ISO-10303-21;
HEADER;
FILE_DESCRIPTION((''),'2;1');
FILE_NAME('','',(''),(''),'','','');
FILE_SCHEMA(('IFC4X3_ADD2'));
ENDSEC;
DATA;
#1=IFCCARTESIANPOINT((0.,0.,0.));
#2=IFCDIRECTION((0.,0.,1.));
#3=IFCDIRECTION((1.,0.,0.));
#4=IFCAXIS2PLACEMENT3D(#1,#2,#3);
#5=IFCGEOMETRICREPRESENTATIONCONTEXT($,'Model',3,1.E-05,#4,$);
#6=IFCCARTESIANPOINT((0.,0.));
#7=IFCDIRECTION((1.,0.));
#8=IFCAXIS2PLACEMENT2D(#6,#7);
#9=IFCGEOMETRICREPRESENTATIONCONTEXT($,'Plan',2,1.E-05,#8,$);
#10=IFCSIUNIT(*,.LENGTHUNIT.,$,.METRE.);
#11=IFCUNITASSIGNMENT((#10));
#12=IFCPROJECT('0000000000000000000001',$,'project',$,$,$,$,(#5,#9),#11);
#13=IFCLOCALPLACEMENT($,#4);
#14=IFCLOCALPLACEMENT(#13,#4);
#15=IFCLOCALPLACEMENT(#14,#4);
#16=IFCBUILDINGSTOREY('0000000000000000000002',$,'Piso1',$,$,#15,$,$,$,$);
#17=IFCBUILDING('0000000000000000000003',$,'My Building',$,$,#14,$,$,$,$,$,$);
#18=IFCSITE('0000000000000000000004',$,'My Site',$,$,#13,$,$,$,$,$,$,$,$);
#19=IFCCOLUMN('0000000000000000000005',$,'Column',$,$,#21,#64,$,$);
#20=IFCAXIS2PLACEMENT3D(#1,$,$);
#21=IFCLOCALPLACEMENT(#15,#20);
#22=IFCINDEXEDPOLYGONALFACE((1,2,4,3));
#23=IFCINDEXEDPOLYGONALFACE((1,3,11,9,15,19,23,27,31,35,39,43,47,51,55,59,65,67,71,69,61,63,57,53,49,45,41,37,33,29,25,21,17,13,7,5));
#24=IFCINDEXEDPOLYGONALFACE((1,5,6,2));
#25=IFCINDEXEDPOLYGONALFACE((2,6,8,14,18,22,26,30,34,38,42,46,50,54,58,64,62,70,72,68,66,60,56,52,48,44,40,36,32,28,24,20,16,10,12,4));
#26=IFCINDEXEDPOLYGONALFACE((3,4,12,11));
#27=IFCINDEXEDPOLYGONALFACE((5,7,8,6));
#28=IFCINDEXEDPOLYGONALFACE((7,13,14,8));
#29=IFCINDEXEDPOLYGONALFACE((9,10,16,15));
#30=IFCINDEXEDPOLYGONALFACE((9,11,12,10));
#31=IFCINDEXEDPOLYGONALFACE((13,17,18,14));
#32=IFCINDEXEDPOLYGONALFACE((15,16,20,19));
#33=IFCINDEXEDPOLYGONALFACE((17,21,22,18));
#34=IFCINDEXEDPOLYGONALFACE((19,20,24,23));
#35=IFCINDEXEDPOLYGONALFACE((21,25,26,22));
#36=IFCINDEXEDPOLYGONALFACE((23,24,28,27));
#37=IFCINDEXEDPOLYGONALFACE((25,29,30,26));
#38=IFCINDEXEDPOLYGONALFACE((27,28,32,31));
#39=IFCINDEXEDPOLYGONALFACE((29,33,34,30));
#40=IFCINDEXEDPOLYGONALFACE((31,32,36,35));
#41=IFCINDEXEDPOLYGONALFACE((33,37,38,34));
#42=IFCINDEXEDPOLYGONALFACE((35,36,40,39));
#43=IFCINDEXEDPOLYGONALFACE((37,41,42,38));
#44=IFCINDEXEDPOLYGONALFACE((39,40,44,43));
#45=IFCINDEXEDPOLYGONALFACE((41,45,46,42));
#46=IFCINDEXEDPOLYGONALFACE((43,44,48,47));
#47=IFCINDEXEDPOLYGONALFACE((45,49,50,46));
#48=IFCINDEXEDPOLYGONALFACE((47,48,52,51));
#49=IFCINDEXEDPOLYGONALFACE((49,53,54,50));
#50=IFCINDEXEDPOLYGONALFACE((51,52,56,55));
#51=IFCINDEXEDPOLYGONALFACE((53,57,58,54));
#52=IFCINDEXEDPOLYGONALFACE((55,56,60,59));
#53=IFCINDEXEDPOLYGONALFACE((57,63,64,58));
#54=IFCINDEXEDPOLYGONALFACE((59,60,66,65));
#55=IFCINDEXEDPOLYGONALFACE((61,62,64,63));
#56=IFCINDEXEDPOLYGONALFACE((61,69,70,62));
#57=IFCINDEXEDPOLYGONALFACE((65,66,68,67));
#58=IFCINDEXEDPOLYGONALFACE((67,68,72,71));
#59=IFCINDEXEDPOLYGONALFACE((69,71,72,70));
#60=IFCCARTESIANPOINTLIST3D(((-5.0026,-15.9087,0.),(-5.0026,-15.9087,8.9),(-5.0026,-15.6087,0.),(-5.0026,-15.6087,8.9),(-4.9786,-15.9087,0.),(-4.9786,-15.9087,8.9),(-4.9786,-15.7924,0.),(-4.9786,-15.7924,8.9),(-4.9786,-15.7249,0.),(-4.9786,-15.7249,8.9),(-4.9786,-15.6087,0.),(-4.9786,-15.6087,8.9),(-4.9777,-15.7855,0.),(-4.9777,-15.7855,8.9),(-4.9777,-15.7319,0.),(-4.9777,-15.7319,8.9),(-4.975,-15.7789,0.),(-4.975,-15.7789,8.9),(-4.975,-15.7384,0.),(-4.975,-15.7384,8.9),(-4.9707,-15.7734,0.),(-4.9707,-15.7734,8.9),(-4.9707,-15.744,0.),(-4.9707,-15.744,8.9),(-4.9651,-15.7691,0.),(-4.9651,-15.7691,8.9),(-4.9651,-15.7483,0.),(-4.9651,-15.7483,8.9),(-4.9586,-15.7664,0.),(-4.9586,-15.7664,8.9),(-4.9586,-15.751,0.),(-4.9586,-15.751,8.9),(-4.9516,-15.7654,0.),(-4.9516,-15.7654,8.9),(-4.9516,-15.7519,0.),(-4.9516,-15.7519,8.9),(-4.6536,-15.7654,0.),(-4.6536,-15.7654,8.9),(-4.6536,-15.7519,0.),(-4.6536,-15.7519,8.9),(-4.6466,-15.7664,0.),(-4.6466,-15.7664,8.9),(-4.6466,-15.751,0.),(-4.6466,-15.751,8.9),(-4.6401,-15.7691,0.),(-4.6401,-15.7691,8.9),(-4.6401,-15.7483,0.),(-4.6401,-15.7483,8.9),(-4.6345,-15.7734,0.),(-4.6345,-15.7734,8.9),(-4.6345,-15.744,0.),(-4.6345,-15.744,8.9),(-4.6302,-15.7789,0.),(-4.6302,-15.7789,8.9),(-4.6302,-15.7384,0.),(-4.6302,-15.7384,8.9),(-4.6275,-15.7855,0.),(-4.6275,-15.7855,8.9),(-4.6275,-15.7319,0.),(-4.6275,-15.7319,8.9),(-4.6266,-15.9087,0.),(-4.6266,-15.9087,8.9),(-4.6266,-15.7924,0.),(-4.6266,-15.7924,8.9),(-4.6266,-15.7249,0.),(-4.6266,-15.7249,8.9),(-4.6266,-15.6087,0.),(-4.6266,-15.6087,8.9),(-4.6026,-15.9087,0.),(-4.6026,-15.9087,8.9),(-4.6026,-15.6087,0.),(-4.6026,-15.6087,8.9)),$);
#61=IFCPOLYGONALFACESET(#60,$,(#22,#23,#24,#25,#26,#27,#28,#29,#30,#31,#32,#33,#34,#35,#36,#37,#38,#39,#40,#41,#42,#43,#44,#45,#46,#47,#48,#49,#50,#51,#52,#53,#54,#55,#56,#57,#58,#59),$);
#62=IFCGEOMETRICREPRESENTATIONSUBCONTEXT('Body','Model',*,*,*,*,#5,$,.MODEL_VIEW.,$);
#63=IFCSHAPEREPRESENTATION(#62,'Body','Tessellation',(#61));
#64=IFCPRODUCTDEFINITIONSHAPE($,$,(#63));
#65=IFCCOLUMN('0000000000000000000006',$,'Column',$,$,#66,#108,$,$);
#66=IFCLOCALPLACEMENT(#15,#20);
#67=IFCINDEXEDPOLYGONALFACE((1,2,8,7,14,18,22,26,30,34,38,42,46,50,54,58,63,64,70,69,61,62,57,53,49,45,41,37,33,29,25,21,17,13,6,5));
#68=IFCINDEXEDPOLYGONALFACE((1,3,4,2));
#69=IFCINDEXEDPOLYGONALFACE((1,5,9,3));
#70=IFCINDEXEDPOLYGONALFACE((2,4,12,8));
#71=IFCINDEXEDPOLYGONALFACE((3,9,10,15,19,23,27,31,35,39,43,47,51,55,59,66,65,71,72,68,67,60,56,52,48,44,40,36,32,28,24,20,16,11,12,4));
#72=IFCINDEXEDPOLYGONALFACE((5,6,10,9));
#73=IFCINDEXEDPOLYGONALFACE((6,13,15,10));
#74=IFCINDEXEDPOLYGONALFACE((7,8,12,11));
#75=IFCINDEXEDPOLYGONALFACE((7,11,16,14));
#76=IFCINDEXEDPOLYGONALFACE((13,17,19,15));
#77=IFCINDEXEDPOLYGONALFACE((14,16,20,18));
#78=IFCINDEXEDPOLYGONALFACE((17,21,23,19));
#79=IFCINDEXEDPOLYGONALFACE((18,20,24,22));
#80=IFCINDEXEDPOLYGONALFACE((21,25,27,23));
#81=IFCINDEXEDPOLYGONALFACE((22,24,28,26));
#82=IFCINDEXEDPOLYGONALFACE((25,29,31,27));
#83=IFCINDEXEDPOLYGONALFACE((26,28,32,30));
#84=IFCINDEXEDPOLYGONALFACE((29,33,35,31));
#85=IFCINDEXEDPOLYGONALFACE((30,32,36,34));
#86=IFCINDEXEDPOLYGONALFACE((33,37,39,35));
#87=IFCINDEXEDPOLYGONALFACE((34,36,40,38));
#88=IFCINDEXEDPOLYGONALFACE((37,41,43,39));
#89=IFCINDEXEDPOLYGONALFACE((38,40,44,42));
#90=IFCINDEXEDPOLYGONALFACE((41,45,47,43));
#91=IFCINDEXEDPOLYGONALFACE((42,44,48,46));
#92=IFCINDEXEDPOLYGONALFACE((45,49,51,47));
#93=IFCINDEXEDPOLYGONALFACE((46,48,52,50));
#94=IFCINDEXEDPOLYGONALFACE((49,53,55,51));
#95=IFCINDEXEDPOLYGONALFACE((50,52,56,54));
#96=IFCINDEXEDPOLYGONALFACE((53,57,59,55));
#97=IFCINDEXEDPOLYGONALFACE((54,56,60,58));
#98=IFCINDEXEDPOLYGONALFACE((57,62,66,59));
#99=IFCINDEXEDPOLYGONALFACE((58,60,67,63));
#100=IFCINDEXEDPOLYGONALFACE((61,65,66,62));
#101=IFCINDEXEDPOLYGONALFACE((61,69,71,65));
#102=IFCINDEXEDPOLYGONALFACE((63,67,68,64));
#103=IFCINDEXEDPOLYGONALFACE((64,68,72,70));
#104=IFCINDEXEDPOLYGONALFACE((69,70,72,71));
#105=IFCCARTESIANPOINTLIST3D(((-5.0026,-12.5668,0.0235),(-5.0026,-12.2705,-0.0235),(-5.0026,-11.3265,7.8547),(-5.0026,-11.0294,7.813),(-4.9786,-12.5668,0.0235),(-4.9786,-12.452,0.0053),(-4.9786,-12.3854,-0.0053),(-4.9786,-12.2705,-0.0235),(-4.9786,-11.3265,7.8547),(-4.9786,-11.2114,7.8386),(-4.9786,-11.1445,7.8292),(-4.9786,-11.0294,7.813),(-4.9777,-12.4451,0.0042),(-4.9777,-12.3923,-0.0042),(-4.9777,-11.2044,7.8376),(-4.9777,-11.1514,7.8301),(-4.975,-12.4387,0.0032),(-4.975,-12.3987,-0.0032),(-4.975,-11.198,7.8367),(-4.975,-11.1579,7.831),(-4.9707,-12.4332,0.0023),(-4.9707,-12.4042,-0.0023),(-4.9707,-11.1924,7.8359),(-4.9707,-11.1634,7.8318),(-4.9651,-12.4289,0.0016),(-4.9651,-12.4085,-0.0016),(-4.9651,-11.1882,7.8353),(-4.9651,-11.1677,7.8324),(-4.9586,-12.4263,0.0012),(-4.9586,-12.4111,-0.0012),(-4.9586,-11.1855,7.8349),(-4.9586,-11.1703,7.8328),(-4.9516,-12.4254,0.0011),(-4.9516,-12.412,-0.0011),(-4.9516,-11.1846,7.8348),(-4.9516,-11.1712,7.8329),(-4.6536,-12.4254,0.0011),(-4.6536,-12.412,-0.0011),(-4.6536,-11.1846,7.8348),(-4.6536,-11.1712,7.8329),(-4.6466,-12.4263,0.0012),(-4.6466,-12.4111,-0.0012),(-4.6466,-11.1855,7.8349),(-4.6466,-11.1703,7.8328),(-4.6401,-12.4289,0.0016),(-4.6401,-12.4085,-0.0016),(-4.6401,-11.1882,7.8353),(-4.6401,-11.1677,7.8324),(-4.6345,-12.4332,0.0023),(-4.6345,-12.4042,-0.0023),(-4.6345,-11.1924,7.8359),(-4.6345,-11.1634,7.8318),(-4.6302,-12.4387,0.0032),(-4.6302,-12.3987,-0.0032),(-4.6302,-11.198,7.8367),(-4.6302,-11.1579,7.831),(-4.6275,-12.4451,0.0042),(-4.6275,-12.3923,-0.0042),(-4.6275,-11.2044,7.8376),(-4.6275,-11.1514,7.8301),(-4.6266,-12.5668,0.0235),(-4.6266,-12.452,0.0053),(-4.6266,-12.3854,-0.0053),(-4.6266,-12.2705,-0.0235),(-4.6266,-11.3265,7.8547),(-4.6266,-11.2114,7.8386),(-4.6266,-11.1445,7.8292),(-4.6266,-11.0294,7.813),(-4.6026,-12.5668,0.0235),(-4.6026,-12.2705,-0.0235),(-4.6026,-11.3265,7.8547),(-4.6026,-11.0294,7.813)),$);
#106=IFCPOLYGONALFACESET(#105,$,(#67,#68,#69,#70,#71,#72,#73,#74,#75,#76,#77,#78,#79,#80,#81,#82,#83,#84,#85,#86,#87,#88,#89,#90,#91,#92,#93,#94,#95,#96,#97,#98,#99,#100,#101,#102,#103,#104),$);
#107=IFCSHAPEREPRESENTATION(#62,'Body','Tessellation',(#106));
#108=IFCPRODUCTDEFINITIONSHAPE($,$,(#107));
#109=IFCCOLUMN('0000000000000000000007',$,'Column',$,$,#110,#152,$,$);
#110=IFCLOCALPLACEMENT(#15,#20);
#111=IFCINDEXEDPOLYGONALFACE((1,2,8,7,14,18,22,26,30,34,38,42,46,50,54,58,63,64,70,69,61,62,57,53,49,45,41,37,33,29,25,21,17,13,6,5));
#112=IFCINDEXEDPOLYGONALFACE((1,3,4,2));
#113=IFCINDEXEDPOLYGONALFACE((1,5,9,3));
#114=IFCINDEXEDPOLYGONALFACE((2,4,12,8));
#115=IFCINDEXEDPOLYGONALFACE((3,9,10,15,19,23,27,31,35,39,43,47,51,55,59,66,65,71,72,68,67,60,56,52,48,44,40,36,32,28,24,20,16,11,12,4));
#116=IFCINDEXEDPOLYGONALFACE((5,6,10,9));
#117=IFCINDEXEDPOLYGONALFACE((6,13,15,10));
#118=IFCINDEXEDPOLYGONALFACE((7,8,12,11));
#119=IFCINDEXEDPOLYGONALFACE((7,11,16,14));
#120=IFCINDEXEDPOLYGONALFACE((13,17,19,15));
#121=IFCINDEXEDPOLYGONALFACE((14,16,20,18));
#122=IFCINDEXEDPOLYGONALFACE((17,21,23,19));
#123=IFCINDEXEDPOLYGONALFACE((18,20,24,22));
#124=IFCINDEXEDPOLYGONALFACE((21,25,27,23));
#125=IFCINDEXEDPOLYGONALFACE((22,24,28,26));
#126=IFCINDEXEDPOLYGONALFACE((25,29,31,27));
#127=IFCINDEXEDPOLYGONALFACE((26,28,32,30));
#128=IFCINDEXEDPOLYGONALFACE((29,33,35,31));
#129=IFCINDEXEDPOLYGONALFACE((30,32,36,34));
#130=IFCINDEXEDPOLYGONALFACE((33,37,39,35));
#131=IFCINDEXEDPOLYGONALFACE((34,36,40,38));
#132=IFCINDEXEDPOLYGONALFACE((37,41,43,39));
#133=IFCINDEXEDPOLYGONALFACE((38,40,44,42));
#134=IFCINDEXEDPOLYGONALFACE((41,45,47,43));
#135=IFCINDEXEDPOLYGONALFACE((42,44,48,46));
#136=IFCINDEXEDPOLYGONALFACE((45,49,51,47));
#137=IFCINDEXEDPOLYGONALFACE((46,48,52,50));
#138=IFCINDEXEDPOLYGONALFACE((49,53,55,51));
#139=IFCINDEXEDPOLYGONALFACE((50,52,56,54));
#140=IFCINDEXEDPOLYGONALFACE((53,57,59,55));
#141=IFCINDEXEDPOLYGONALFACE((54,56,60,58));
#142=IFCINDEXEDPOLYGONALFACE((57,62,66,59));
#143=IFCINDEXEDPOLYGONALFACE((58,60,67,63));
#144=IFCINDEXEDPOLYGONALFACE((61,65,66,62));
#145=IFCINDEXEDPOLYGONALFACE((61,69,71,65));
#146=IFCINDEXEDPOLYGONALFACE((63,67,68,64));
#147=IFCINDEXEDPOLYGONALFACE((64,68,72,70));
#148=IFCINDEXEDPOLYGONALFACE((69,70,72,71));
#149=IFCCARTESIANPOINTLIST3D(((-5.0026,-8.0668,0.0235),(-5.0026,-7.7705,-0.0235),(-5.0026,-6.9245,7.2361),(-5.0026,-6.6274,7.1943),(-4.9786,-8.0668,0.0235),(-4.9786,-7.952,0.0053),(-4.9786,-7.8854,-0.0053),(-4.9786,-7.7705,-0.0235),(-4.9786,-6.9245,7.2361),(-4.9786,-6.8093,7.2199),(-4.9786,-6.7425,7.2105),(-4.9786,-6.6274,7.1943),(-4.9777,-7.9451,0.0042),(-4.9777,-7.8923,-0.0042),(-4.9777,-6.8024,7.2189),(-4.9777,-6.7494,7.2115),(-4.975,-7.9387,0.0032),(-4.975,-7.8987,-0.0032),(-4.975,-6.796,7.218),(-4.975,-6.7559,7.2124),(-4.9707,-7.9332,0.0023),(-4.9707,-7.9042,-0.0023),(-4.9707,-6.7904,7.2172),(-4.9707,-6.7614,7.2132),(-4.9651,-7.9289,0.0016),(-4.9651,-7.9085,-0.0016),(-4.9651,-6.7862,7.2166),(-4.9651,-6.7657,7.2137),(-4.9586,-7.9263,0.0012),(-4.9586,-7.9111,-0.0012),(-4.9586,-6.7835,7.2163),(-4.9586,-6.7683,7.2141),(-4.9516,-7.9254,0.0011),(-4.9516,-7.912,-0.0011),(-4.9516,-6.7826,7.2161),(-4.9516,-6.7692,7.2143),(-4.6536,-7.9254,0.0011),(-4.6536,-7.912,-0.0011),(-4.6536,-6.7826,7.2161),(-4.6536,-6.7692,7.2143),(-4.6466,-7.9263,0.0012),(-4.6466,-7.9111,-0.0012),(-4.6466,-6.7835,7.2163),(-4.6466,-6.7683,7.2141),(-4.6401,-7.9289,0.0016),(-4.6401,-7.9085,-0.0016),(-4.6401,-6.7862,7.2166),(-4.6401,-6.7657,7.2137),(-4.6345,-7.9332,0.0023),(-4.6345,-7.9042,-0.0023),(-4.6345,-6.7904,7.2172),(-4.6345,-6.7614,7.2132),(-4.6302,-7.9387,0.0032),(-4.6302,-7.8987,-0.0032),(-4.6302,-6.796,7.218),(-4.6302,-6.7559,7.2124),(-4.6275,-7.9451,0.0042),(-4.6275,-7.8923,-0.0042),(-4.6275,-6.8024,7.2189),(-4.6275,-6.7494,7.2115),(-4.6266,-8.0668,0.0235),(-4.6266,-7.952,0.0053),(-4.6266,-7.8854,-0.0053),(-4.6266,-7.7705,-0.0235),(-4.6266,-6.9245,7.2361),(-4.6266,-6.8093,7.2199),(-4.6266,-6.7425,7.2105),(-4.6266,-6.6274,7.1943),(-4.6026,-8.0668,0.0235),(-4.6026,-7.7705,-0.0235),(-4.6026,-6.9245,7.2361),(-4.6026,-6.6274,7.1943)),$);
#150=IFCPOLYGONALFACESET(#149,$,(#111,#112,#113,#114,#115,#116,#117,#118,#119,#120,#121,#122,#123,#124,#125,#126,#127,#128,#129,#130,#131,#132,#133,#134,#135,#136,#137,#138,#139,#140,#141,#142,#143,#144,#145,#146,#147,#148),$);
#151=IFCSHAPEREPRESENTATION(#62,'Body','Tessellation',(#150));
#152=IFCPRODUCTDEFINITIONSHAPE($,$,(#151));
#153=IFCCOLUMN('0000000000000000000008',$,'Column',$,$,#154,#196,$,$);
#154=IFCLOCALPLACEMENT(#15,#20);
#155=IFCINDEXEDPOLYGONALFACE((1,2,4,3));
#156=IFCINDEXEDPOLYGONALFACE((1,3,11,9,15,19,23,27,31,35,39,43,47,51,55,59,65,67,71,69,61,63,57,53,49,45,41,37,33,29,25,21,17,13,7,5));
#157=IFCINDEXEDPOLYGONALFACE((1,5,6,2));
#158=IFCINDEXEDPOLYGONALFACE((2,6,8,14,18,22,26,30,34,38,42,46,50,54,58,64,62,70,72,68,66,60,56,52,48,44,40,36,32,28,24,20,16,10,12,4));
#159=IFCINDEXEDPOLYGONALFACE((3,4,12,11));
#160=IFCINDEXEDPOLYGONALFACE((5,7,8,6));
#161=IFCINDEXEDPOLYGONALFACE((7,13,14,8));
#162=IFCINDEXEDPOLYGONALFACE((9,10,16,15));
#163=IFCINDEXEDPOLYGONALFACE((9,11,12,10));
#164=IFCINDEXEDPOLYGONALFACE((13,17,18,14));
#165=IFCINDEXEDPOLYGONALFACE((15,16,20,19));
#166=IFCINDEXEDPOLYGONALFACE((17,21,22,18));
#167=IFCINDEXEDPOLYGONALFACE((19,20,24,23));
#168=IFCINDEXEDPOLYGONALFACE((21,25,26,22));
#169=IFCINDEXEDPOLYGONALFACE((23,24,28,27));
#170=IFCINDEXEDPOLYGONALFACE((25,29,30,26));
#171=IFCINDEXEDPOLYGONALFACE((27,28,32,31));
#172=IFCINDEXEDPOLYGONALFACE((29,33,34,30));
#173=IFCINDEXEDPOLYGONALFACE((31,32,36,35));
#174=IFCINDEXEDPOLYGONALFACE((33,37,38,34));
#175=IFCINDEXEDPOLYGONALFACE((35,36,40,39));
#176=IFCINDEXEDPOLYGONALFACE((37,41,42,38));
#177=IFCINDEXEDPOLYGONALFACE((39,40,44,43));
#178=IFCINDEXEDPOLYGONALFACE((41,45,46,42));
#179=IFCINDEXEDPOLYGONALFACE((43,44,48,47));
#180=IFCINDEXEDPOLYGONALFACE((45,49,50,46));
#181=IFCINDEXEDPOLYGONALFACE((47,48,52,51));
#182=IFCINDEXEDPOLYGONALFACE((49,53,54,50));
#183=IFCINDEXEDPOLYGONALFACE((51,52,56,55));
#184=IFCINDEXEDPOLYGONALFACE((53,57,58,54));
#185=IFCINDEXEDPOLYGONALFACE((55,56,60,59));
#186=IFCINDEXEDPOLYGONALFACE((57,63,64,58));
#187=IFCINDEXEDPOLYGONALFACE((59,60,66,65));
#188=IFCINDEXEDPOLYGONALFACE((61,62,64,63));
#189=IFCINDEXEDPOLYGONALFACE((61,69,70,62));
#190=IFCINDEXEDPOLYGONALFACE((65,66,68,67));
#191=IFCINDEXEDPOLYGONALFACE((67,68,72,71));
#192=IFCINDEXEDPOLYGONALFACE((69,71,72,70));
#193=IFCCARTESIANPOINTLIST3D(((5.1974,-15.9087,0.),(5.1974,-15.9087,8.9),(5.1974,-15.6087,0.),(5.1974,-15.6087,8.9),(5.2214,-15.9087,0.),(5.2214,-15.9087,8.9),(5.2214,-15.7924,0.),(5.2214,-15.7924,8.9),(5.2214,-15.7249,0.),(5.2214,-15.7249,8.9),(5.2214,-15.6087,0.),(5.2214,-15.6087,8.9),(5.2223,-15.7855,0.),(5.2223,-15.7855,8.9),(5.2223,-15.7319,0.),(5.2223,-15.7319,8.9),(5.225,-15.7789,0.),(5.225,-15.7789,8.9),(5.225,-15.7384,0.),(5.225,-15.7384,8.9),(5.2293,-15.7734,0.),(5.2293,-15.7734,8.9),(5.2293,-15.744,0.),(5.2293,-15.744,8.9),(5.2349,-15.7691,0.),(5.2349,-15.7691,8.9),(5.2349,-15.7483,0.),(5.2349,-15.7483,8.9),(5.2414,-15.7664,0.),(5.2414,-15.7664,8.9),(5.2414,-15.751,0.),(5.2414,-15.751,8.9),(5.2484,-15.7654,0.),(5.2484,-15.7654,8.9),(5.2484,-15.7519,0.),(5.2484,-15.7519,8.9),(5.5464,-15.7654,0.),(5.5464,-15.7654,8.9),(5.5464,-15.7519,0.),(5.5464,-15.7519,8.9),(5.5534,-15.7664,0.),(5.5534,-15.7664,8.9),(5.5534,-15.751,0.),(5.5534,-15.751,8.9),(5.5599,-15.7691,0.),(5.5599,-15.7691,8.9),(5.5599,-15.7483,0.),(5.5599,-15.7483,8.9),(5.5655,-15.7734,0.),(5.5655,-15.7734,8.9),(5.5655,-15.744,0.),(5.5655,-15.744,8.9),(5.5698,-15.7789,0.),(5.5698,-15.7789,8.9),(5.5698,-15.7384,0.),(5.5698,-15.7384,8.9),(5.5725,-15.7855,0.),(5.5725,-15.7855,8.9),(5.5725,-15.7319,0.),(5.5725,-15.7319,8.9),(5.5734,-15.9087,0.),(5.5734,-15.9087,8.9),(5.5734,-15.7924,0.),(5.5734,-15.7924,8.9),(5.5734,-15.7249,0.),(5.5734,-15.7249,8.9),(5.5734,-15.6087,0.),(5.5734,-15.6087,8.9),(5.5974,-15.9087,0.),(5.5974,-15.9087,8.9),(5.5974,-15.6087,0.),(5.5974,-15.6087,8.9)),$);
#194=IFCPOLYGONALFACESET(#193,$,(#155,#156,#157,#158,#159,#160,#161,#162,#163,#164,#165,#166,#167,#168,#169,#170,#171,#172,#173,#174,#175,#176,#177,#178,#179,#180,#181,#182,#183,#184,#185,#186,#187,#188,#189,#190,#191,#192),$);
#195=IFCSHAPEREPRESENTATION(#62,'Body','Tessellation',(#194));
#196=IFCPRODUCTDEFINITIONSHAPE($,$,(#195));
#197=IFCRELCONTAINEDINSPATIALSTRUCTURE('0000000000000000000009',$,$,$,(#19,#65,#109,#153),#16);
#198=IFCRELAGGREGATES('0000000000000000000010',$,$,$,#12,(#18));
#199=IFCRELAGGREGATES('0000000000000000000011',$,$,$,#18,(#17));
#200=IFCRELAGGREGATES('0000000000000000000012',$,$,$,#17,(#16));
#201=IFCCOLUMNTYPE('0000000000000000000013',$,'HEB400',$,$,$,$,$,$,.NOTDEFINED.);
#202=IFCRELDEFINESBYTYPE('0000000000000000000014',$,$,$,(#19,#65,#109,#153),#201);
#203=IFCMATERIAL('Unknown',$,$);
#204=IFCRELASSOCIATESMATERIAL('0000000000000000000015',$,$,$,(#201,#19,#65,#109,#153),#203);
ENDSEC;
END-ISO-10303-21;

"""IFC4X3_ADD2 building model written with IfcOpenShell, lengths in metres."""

from ifc_helpers import new_model, si_unit, frame, origin_with_axes, origin_2d_with_axis, place, context, subcontext, project, spatial, i_section, extrude, clip, halfspace, material, material_profile, profile_set, profile_usage, type_object, element, save


model = new_model("IFC4X3_ADD2")

# Units and contexts
model_context = context("Model", 3, precision=1e-05, world=origin_with_axes())
plan_context = context("Plan", 2, precision=1e-05, world=origin_2d_with_axis())
body_context_1 = subcontext(model_context, "Body", "Model", "MODEL_VIEW")
ifc_project = project(units=[si_unit("LENGTHUNIT", "METRE")], contexts=[model_context, plan_context])

# Site, building, storey
site_placement = place(None, origin_with_axes())
site = spatial("IfcSite", under=ifc_project, at=site_placement, Name="My Site")
building_placement = place(site_placement, origin_with_axes())
building = spatial("IfcBuilding", under=site, at=building_placement, Name="My Building")
storey_placement = place(building_placement, origin_with_axes())
storey = spatial("IfcBuildingStorey", under=building, at=storey_placement, Name="Piso1")

# Columns
ifc_material_1 = material(Name="Unknown")
ifc_material_profile_1 = material_profile(ifc_material_1, i_section(OverallWidth=0.3, OverallDepth=0.4, WebThickness=0.0135, FlangeThickness=0.024, FilletRadius=0.027))
ifc_profile_set_1 = profile_set([ifc_material_profile_1])
ifc_profile_usage_1 = profile_usage(ifc_profile_set_1, cardinal=5)
column_type_1 = type_object("IfcColumnType", Name="HEB400", PredefinedType="NOTDEFINED", material=ifc_profile_set_1)
column_1_placement = place(storey_placement, frame((-4.8026, -15.7587, 0.0), z_axis=(0.0, 0.0, 1.0), x_axis=(0.0, 1.0, 0.0)))
element("IfcColumn", 1, at=column_1_placement, inside=storey, type_object=column_type_1, material=ifc_profile_usage_1, Name="Column", context=body_context_1, shape_type="SweptSolid", body=[
    extrude(i_section(OverallWidth=0.3, OverallDepth=0.4, WebThickness=0.0135, FlangeThickness=0.024, FilletRadius=0.027), origin_with_axes(), (0.0, 0.0, 1.0), 8.9),
])
ifc_profile_usage_2 = profile_usage(ifc_profile_set_1, cardinal=5)
column_2_placement = place(storey_placement, frame((-4.8026, -12.4187, 0.0), z_axis=(0.0, 0.156434, 0.987688), x_axis=(0.0, 0.987688, -0.156434)))
element("IfcColumn", 2, at=column_2_placement, inside=storey, type_object=column_type_1, material=ifc_profile_usage_2, Name="Column", context=body_context_1, shape_type="Clipping", body=[
    clip(extrude(i_section(OverallWidth=0.3, OverallDepth=0.4, WebThickness=0.0135, FlangeThickness=0.024, FilletRadius=0.027), origin_with_axes(), (0.0, 0.0, 1.0), 8.3315), halfspace(frame((-4.6772, -0.11, 7.8499), z_axis=(-0.017453, 0.0, 0.999848), x_axis=(-0.000003, 1.0, 0.0)), False)),
])
ifc_profile_usage_3 = profile_usage(ifc_profile_set_1, cardinal=5)
column_3_placement = place(storey_placement, frame((-4.8026, -7.9187, 0.0), z_axis=(0.0, 0.156434, 0.987688), x_axis=(0.0, 0.987688, -0.156434)))
element("IfcColumn", 3, at=column_3_placement, inside=storey, type_object=column_type_1, material=ifc_profile_usage_3, Name="Column", context=body_context_1, shape_type="Clipping", body=[
    clip(extrude(i_section(OverallWidth=0.3, OverallDepth=0.4, WebThickness=0.0135, FlangeThickness=0.024, FilletRadius=0.027), origin_with_axes(), (0.0, 0.0, 1.0), 7.7051), halfspace(frame((-9.1218, -0.11, 7.1459), z_axis=(-0.017453, 0.0, 0.999848), x_axis=(-0.000003, 1.0, 0.0)), False)),
])
ifc_profile_usage_4 = profile_usage(ifc_profile_set_1, cardinal=5)
column_4_placement = place(storey_placement, frame((5.3974, -15.7587, 0.0), z_axis=(0.0, 0.0, 1.0), x_axis=(0.0, 1.0, 0.0)))
element("IfcColumn", 4, at=column_4_placement, inside=storey, type_object=column_type_1, material=ifc_profile_usage_4, Name="Column", context=body_context_1, shape_type="SweptSolid", body=[
    extrude(i_section(OverallWidth=0.3, OverallDepth=0.4, WebThickness=0.0135, FlangeThickness=0.024, FilletRadius=0.027), origin_with_axes(), (0.0, 0.0, 1.0), 8.9),
])

save(model, "model.ifc")
